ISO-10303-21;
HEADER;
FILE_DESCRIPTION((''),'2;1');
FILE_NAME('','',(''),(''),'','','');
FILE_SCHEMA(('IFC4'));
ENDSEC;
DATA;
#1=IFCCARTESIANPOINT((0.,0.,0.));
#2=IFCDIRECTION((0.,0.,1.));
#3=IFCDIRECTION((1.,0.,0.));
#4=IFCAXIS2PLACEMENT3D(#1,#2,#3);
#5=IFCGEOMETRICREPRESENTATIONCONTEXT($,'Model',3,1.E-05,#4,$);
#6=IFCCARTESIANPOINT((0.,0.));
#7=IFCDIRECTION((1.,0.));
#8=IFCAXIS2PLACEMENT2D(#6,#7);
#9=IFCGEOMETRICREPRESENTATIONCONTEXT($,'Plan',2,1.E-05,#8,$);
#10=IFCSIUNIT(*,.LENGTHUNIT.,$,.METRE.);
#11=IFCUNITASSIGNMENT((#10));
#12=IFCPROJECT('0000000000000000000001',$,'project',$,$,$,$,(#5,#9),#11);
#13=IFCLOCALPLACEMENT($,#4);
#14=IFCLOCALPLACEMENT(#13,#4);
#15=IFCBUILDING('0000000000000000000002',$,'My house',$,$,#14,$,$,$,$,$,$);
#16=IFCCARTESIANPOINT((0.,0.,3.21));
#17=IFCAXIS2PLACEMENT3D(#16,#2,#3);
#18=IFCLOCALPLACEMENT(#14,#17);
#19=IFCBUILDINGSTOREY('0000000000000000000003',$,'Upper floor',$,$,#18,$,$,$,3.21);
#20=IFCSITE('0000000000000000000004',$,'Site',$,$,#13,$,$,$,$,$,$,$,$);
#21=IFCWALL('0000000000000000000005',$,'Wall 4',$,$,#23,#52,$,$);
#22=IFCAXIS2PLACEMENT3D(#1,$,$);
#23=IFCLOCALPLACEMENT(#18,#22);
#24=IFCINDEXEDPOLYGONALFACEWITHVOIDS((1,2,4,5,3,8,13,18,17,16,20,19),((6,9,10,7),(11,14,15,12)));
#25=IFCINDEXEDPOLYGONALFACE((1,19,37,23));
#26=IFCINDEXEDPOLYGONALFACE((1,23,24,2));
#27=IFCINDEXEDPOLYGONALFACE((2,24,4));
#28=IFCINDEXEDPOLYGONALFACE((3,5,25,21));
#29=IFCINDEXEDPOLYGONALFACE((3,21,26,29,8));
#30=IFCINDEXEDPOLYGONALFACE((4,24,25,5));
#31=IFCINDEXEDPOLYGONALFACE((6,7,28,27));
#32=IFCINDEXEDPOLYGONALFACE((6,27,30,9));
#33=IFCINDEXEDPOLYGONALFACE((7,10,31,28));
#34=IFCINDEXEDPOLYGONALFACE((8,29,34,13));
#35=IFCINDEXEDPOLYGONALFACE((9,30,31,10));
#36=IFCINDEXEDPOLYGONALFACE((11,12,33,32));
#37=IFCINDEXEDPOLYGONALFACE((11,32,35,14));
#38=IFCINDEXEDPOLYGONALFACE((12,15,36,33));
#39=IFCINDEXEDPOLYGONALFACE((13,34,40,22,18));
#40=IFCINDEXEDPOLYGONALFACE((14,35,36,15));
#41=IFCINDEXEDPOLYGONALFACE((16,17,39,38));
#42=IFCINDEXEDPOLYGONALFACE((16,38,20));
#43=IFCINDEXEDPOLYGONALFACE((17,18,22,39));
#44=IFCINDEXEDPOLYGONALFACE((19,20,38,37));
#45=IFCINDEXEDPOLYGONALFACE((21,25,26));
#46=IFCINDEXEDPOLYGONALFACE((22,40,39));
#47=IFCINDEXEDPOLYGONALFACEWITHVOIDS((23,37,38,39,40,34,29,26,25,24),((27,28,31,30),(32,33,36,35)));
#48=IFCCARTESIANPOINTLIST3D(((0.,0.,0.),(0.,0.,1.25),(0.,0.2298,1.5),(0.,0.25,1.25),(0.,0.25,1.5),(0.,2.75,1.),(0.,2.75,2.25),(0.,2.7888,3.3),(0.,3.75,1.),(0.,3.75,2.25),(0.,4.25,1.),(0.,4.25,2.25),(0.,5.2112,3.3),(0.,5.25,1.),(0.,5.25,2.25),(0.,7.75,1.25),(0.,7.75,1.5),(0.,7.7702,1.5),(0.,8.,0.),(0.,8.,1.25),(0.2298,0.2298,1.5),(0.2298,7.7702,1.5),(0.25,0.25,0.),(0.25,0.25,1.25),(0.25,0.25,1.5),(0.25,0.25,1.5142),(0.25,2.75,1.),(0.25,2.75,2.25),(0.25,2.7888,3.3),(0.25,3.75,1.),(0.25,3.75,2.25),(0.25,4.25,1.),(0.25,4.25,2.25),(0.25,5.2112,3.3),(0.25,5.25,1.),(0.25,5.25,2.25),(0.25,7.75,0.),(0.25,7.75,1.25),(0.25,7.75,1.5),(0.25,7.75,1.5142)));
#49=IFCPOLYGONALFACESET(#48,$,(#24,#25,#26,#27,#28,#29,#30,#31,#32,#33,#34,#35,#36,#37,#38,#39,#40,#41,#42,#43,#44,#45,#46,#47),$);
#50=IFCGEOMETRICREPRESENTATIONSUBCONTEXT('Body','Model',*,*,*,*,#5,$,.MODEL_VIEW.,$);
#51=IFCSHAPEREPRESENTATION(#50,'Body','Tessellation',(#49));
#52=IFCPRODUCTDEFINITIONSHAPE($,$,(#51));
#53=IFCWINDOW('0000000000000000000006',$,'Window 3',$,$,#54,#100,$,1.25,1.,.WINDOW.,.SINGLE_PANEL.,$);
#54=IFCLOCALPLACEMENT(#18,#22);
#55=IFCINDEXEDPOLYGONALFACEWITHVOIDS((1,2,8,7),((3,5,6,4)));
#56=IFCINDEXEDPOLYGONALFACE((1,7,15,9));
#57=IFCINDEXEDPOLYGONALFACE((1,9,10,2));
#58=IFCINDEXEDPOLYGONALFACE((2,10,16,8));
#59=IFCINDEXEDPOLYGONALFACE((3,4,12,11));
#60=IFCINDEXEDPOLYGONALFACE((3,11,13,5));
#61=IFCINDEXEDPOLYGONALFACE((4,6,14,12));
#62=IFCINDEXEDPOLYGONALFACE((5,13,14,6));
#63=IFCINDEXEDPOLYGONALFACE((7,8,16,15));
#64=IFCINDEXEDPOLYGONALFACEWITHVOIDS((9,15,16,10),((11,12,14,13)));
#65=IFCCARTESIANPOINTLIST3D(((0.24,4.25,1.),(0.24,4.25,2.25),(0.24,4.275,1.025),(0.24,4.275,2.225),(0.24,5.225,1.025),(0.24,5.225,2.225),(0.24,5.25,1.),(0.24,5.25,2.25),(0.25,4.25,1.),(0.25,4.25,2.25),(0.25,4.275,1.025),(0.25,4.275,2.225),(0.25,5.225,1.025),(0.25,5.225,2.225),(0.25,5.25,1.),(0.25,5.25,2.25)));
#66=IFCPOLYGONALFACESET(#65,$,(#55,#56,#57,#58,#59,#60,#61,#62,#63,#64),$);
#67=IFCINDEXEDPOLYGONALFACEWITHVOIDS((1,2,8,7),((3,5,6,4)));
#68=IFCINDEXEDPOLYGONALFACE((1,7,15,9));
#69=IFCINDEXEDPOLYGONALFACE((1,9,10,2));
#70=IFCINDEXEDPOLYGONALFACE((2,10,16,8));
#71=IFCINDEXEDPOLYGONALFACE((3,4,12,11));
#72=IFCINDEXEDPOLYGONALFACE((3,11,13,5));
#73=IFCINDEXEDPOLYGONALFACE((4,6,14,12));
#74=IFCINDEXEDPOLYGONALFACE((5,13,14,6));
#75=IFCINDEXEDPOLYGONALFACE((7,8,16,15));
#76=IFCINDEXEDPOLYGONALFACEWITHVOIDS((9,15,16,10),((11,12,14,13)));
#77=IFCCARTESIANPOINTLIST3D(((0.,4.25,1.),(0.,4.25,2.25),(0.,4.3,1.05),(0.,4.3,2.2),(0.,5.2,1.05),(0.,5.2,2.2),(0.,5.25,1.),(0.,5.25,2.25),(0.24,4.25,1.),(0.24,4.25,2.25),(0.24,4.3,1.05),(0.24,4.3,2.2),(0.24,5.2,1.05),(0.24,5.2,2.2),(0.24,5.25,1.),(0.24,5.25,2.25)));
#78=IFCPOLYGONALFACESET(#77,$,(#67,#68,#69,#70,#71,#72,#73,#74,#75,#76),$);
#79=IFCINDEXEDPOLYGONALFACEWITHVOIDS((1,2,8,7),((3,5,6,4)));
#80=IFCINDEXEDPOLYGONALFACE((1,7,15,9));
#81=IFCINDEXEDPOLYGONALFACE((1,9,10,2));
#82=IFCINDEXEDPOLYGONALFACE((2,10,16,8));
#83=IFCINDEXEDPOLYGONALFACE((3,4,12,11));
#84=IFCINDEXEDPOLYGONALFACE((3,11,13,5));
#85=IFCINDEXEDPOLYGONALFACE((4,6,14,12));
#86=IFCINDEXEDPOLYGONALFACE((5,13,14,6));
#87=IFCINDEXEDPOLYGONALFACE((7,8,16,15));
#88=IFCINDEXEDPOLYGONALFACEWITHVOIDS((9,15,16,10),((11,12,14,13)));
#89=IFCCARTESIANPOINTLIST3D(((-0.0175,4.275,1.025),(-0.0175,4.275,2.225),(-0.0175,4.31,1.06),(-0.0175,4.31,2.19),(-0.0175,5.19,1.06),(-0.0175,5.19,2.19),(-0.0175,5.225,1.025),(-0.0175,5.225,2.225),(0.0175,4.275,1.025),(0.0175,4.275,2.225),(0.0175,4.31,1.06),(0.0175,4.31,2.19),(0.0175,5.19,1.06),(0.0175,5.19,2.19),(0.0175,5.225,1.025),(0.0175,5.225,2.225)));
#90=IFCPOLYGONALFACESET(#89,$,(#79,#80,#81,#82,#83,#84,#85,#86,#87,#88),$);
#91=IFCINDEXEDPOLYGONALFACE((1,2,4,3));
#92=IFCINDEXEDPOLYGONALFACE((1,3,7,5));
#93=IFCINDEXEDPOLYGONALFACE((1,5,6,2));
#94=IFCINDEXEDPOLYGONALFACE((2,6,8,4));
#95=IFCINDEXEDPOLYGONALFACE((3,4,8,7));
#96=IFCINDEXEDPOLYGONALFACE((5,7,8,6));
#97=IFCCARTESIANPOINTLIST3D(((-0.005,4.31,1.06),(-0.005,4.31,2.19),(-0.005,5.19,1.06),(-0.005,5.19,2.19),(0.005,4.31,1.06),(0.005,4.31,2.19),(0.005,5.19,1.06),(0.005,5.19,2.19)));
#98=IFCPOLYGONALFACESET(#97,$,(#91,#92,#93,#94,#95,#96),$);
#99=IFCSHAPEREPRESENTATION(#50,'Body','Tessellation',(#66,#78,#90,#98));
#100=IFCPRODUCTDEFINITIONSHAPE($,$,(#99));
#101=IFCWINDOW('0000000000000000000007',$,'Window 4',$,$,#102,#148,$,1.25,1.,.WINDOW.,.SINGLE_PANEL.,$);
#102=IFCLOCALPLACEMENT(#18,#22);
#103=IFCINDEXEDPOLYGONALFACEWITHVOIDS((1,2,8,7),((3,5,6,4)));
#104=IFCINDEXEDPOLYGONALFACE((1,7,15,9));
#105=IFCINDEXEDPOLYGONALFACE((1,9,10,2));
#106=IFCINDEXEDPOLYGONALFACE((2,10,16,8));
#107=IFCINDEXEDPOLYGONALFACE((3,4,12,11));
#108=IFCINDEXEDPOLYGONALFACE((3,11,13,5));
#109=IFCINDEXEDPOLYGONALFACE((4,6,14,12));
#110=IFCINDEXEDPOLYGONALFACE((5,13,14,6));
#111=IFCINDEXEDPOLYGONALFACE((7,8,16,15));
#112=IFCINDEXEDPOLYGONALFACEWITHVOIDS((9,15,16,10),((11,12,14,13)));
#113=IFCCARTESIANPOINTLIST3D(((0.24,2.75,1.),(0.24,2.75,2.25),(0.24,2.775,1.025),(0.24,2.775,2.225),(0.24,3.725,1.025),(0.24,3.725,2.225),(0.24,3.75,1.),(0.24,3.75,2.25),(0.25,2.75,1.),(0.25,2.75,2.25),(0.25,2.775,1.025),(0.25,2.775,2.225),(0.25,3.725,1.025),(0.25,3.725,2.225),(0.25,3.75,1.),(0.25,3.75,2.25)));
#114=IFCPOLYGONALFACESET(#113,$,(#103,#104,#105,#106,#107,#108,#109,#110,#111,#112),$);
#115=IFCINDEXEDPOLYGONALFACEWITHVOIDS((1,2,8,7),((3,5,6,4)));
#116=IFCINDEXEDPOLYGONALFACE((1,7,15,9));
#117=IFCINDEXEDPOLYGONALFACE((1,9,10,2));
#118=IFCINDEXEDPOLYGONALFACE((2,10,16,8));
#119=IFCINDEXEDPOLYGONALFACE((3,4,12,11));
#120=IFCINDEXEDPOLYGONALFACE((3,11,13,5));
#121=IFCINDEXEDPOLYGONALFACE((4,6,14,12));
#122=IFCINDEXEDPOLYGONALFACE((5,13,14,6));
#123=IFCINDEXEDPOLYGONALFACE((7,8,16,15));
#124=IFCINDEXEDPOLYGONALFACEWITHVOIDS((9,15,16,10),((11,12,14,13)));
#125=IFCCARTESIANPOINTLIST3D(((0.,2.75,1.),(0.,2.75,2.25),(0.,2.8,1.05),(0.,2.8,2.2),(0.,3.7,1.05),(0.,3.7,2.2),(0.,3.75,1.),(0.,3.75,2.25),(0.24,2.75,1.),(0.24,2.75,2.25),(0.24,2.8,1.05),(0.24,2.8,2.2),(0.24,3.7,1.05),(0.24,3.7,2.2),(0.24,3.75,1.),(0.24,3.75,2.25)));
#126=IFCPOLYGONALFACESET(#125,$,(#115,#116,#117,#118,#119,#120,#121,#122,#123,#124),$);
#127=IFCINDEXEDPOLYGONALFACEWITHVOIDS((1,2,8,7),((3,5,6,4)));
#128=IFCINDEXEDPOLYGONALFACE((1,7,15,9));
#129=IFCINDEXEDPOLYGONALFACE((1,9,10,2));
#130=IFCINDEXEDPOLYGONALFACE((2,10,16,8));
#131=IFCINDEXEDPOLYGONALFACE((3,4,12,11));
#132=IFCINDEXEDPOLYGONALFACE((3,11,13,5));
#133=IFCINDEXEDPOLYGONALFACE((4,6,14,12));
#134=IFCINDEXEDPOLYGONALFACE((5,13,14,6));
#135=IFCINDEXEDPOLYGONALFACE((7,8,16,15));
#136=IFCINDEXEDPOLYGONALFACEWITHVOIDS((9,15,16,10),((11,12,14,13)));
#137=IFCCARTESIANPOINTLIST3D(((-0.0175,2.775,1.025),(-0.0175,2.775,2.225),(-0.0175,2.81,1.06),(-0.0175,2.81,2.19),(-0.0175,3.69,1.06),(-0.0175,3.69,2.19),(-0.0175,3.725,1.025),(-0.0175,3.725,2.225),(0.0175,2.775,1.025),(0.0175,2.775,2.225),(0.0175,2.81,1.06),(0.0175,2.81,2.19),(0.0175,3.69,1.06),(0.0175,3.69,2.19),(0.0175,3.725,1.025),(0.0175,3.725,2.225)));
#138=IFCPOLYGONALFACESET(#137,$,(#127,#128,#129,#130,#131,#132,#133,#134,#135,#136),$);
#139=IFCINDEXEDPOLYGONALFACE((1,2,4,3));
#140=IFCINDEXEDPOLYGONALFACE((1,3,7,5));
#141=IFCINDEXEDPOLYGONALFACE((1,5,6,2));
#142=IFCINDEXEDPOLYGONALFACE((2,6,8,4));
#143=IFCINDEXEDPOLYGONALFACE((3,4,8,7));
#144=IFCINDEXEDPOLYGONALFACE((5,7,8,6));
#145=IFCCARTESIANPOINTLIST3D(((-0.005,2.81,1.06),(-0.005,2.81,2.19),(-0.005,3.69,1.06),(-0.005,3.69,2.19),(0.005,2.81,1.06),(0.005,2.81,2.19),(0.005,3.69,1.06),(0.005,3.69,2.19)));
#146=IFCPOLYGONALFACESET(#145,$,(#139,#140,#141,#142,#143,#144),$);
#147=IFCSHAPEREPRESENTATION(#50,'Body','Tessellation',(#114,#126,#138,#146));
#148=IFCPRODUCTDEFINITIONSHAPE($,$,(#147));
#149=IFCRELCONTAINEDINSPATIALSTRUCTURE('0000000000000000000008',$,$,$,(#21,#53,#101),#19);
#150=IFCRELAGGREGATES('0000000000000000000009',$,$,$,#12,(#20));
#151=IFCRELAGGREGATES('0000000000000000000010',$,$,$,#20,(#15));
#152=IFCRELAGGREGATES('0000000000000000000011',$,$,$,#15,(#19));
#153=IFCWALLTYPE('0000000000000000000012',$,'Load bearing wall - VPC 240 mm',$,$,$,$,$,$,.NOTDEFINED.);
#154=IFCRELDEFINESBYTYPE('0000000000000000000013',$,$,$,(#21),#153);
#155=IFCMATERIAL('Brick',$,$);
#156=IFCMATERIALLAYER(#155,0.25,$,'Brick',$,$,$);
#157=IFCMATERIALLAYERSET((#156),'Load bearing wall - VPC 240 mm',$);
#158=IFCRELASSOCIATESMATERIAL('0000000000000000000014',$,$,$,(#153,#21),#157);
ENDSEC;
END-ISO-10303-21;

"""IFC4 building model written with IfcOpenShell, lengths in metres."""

from ifc_helpers import new_model, entity, si_unit, frame, origin_with_axes, origin_2d_with_axis, place, context, subcontext, project, spatial, line, indexed_curve, outline, extrude, clip, halfspace, shape, material, layer, layer_set, layer_usage, type_object, element, fill, save


model = new_model("IFC4")

# Units and contexts
model_context = context("Model", 3, precision=1e-05, world=origin_with_axes())
plan_context = context("Plan", 2, precision=1e-05, world=origin_2d_with_axis())
body_context_1 = subcontext(model_context, "Body", "Model", "MODEL_VIEW")
body_context_2 = subcontext(plan_context, "Body", "Plan", "PLAN_VIEW")
ifc_project = project(units=[si_unit("LENGTHUNIT", "METRE")], contexts=[model_context, plan_context])

# Site, building, storey
site_placement = place(None, origin_with_axes())
site = spatial("IfcSite", under=ifc_project, at=site_placement, Name="Site")
building_placement = place(site_placement, origin_with_axes())
building = spatial("IfcBuilding", under=site, at=building_placement, Name="My house")
storey_placement = place(building_placement, frame((0.0, 0.0, 3.21), z_axis=(0.0, 0.0, 1.0), x_axis=(1.0, 0.0, 0.0)))
storey = spatial("IfcBuildingStorey", under=building, at=storey_placement, Name="Upper floor", Elevation=3.21)

# Shared definitions
ifc_material_1 = material(Name="Brick")
ifc_layer_1 = layer(ifc_material_1, 0.25, Name="Brick")
ifc_layer_set_1 = layer_set([ifc_layer_1], Name="Load bearing wall - VPC 240 mm")
wall_type_1 = type_object("IfcWallType", Name="Load bearing wall - VPC 240 mm", PredefinedType="NOTDEFINED", material=ifc_layer_set_1)

# Wall, openings, windows
ifc_layer_usage_1 = layer_usage(ifc_layer_set_1, "AXIS2", "NEGATIVE", 0.25)
wall_1_placement = place(storey_placement, frame((0.0, 8.0, 0.0), z_axis=(0.0, 0.0, 1.0), x_axis=(0.0, -1.0, 0.0)))
wall_1 = element("IfcWall", 1, at=wall_1_placement, inside=storey, type_object=wall_type_1, material=ifc_layer_usage_1, Name="Wall 4", context=body_context_1, shape_type="Clipping", body=[
    clip(clip(clip(extrude(outline(indexed_curve([(0.0, 0.0), (0.25, 0.25), (7.75, 0.25), (8.0, 0.0)], segments=[line(1, 2, 3, 4, 1)])), origin_with_axes(), (0.0, 0.0, 1.0), 4.0), halfspace(frame((7.955, 0.0, 1.37), z_axis=(0.575329, 0.0, 0.817922), x_axis=(0.0, -1.0, 0.0)), False)), halfspace(frame((0.045, 0.0, 1.37), z_axis=(-0.575329, 0.0, 0.817922), x_axis=(0.0, 1.0, 0.0)), False)), halfspace(frame((4.87, 0.0, 3.3), z_axis=(0.0, 0.0, 1.0), x_axis=(-1.0, 0.0, 0.0)), False)),
])
opening_1_placement = place(wall_1_placement, frame((0.0, 0.0, 1.25), z_axis=(0.0, 0.0, 1.0), x_axis=(1.0, 0.0, 0.0)))
element("IfcOpeningElement", 2, at=opening_1_placement, cuts=wall_1, PredefinedType="OPENING", context=body_context_1, shape_type="SweptSolid", body=[
    extrude(outline(indexed_curve([(0.0, 0.0), (0.0, 0.35), (0.25, 0.35), (0.25, 0.0), (0.0, 0.0)], self_intersect=False)), frame((0.0, -0.05, 0.0), z_axis=(0.0, 0.0, 1.0), x_axis=(1.0, 0.0, 0.0)), (0.0, 0.0, 1.0), 0.25),
])
opening_2_placement = place(wall_1_placement, frame((7.75, 0.0, 1.25), z_axis=(0.0, 0.0, 1.0), x_axis=(1.0, 0.0, 0.0)))
element("IfcOpeningElement", 3, at=opening_2_placement, cuts=wall_1, PredefinedType="OPENING", context=body_context_1, shape_type="SweptSolid", body=[
    extrude(outline(indexed_curve([(0.0, 0.0), (0.0, 0.35), (0.25, 0.35), (0.25, 0.0), (0.0, 0.0)], self_intersect=False)), frame((0.0, -0.05, 0.0), z_axis=(0.0, 0.0, 1.0), x_axis=(1.0, 0.0, 0.0)), (0.0, 0.0, 1.0), 0.25),
])
opening_3_placement = place(wall_1_placement, frame((2.75, 0.0, 1.0), z_axis=(0.0, 0.0, 1.0), x_axis=(1.0, 0.0, 0.0)))
opening_3 = element("IfcOpeningElement", 4, at=opening_3_placement, cuts=wall_1, PredefinedType="OPENING", context=body_context_1, shape_type="SweptSolid", body=[
    extrude(outline(indexed_curve([(0.0, 0.0), (0.0, 0.35), (1.0, 0.35), (1.0, 0.0), (0.0, 0.0)], self_intersect=False)), frame((0.0, -0.05, 0.0), z_axis=(0.0, 0.0, 1.0), x_axis=(1.0, 0.0, 0.0)), (0.0, 0.0, 1.0), 1.25),
])
opening_4_placement = place(wall_1_placement, frame((4.25, 0.0, 1.0), z_axis=(0.0, 0.0, 1.0), x_axis=(1.0, 0.0, 0.0)))
opening_4 = element("IfcOpeningElement", 5, at=opening_4_placement, cuts=wall_1, PredefinedType="OPENING", context=body_context_1, shape_type="SweptSolid", body=[
    extrude(outline(indexed_curve([(0.0, 0.0), (0.0, 0.35), (1.0, 0.35), (1.0, 0.0), (0.0, 0.0)], self_intersect=False)), frame((0.0, -0.05, 0.0), z_axis=(0.0, 0.0, 1.0), x_axis=(1.0, 0.0, 0.0)), (0.0, 0.0, 1.0), 1.25),
])
window_1_placement = place(opening_3_placement, origin_with_axes())
window_1 = element("IfcWindow", 6, at=window_1_placement, inside=storey, Name="Window 3", OverallHeight=1.25, OverallWidth=1.0, PartitioningType="SINGLE_PANEL", PredefinedType="WINDOW", shapes=[
    shape(body_context_1, "Body", "SweptSolid", [extrude(outline(indexed_curve([(0.0, 0.0), (1.0, 0.0), (1.0, 1.25), (0.0, 1.25)], segments=[line(1, 2, 3, 4, 1)]), holes=[indexed_curve([(0.025, 0.025), (0.975, 0.025), (0.975, 1.225), (0.025, 1.225)], segments=[line(1, 2, 3, 4, 1)])]), frame((0.0, 0.24, 0.0), z_axis=(0.0, -1.0, 0.0), x_axis=(1.0, 0.0, 0.0)), (0.0, 0.0, -1.0), 0.01), extrude(outline(indexed_curve([(0.0, 0.0), (1.0, 0.0), (1.0, 1.25), (0.0, 1.25)], segments=[line(1, 2, 3, 4, 1)]), holes=[indexed_curve([(0.05, 0.05), (0.95, 0.05), (0.95, 1.2), (0.05, 1.2)], segments=[line(1, 2, 3, 4, 1)])]), frame((0.0, 0.0, 0.0), z_axis=(0.0, -1.0, 0.0), x_axis=(1.0, 0.0, 0.0)), (0.0, 0.0, -1.0), 0.24), extrude(outline(indexed_curve([(0.0, 0.0), (0.95, 0.0), (0.95, 1.2), (0.0, 1.2)], segments=[line(1, 2, 3, 4, 1)]), holes=[indexed_curve([(0.035, 0.035), (0.915, 0.035), (0.915, 1.165), (0.035, 1.165)], segments=[line(1, 2, 3, 4, 1)])]), frame((0.025, -0.0175, 0.025), z_axis=(0.0, -1.0, 0.0), x_axis=(1.0, 0.0, 0.0)), (0.0, 0.0, -1.0), 0.035), extrude(outline(indexed_curve([(0.035, 0.035), (0.915, 0.035), (0.915, 1.165), (0.035, 1.165)], segments=[line(1, 2, 3, 4, 1)])), frame((0.025, -0.005, 0.025), z_axis=(0.0, -1.0, 0.0), x_axis=(1.0, 0.0, 0.0)), (0.0, 0.0, -1.0), 0.01)]),
    shape(body_context_2, "Body", "Curve2D", [entity("IfcIndexedPolyCurve", entity("IfcCartesianPointList2D", [[0.05, 0.0], [0.95, 0.0]])), entity("IfcIndexedPolyCurve", entity("IfcCartesianPointList2D", [[0.0, 0.25], [0.025, 0.25], [0.025, 0.24], [0.05, 0.24], [0.05, 0.0], [0.0, 0.0]]), [entity("IfcLineIndex", [1, 2, 3, 4, 5, 6, 1])]), entity("IfcIndexedPolyCurve", entity("IfcCartesianPointList2D", [[1.0, 0.25], [0.975, 0.25], [0.975, 0.24], [0.95, 0.24], [0.95, 0.0], [1.0, 0.0]]), [entity("IfcLineIndex", [1, 2, 3, 4, 5, 6, 1])]), entity("IfcIndexedPolyCurve", entity("IfcCartesianPointList2D", [[0.025, -0.0175], [0.06, -0.0175], [0.06, 0.0175], [0.025, 0.0175]]), [entity("IfcLineIndex", [1, 2, 3, 4, 1])]), entity("IfcIndexedPolyCurve", entity("IfcCartesianPointList2D", [[0.975, -0.0175], [0.94, -0.0175], [0.94, 0.0175], [0.975, 0.0175]]), [entity("IfcLineIndex", [1, 2, 3, 4, 1])]), entity("IfcIndexedPolyCurve", entity("IfcCartesianPointList2D", [[0.06, -0.0175], [0.94, -0.0175]])), entity("IfcIndexedPolyCurve", entity("IfcCartesianPointList2D", [[0.06, 0.0175], [0.94, 0.0175]])), entity("IfcIndexedPolyCurve", entity("IfcCartesianPointList2D", [[0.06, 0.0], [0.94, 0.0]]))]),
])
fill(opening_3, window_1)
window_2_placement = place(opening_4_placement, origin_with_axes())
window_2 = element("IfcWindow", 7, at=window_2_placement, inside=storey, Name="Window 4", OverallHeight=1.25, OverallWidth=1.0, PartitioningType="SINGLE_PANEL", PredefinedType="WINDOW", shapes=[
    shape(body_context_1, "Body", "SweptSolid", [extrude(outline(indexed_curve([(0.0, 0.0), (1.0, 0.0), (1.0, 1.25), (0.0, 1.25)], segments=[line(1, 2, 3, 4, 1)]), holes=[indexed_curve([(0.025, 0.025), (0.975, 0.025), (0.975, 1.225), (0.025, 1.225)], segments=[line(1, 2, 3, 4, 1)])]), frame((0.0, 0.24, 0.0), z_axis=(0.0, -1.0, 0.0), x_axis=(1.0, 0.0, 0.0)), (0.0, 0.0, -1.0), 0.01), extrude(outline(indexed_curve([(0.0, 0.0), (1.0, 0.0), (1.0, 1.25), (0.0, 1.25)], segments=[line(1, 2, 3, 4, 1)]), holes=[indexed_curve([(0.05, 0.05), (0.95, 0.05), (0.95, 1.2), (0.05, 1.2)], segments=[line(1, 2, 3, 4, 1)])]), frame((0.0, 0.0, 0.0), z_axis=(0.0, -1.0, 0.0), x_axis=(1.0, 0.0, 0.0)), (0.0, 0.0, -1.0), 0.24), extrude(outline(indexed_curve([(0.0, 0.0), (0.95, 0.0), (0.95, 1.2), (0.0, 1.2)], segments=[line(1, 2, 3, 4, 1)]), holes=[indexed_curve([(0.035, 0.035), (0.915, 0.035), (0.915, 1.165), (0.035, 1.165)], segments=[line(1, 2, 3, 4, 1)])]), frame((0.025, -0.0175, 0.025), z_axis=(0.0, -1.0, 0.0), x_axis=(1.0, 0.0, 0.0)), (0.0, 0.0, -1.0), 0.035), extrude(outline(indexed_curve([(0.035, 0.035), (0.915, 0.035), (0.915, 1.165), (0.035, 1.165)], segments=[line(1, 2, 3, 4, 1)])), frame((0.025, -0.005, 0.025), z_axis=(0.0, -1.0, 0.0), x_axis=(1.0, 0.0, 0.0)), (0.0, 0.0, -1.0), 0.01)]),
    shape(body_context_2, "Body", "Curve2D", [entity("IfcIndexedPolyCurve", entity("IfcCartesianPointList2D", [[0.05, 0.0], [0.95, 0.0]])), entity("IfcIndexedPolyCurve", entity("IfcCartesianPointList2D", [[0.0, 0.25], [0.025, 0.25], [0.025, 0.24], [0.05, 0.24], [0.05, 0.0], [0.0, 0.0]]), [entity("IfcLineIndex", [1, 2, 3, 4, 5, 6, 1])]), entity("IfcIndexedPolyCurve", entity("IfcCartesianPointList2D", [[1.0, 0.25], [0.975, 0.25], [0.975, 0.24], [0.95, 0.24], [0.95, 0.0], [1.0, 0.0]]), [entity("IfcLineIndex", [1, 2, 3, 4, 5, 6, 1])]), entity("IfcIndexedPolyCurve", entity("IfcCartesianPointList2D", [[0.025, -0.0175], [0.06, -0.0175], [0.06, 0.0175], [0.025, 0.0175]]), [entity("IfcLineIndex", [1, 2, 3, 4, 1])]), entity("IfcIndexedPolyCurve", entity("IfcCartesianPointList2D", [[0.975, -0.0175], [0.94, -0.0175], [0.94, 0.0175], [0.975, 0.0175]]), [entity("IfcLineIndex", [1, 2, 3, 4, 1])]), entity("IfcIndexedPolyCurve", entity("IfcCartesianPointList2D", [[0.06, -0.0175], [0.94, -0.0175]])), entity("IfcIndexedPolyCurve", entity("IfcCartesianPointList2D", [[0.06, 0.0175], [0.94, 0.0175]])), entity("IfcIndexedPolyCurve", entity("IfcCartesianPointList2D", [[0.06, 0.0], [0.94, 0.0]]))]),
])
fill(opening_4, window_2)

save(model, "model.ifc")
